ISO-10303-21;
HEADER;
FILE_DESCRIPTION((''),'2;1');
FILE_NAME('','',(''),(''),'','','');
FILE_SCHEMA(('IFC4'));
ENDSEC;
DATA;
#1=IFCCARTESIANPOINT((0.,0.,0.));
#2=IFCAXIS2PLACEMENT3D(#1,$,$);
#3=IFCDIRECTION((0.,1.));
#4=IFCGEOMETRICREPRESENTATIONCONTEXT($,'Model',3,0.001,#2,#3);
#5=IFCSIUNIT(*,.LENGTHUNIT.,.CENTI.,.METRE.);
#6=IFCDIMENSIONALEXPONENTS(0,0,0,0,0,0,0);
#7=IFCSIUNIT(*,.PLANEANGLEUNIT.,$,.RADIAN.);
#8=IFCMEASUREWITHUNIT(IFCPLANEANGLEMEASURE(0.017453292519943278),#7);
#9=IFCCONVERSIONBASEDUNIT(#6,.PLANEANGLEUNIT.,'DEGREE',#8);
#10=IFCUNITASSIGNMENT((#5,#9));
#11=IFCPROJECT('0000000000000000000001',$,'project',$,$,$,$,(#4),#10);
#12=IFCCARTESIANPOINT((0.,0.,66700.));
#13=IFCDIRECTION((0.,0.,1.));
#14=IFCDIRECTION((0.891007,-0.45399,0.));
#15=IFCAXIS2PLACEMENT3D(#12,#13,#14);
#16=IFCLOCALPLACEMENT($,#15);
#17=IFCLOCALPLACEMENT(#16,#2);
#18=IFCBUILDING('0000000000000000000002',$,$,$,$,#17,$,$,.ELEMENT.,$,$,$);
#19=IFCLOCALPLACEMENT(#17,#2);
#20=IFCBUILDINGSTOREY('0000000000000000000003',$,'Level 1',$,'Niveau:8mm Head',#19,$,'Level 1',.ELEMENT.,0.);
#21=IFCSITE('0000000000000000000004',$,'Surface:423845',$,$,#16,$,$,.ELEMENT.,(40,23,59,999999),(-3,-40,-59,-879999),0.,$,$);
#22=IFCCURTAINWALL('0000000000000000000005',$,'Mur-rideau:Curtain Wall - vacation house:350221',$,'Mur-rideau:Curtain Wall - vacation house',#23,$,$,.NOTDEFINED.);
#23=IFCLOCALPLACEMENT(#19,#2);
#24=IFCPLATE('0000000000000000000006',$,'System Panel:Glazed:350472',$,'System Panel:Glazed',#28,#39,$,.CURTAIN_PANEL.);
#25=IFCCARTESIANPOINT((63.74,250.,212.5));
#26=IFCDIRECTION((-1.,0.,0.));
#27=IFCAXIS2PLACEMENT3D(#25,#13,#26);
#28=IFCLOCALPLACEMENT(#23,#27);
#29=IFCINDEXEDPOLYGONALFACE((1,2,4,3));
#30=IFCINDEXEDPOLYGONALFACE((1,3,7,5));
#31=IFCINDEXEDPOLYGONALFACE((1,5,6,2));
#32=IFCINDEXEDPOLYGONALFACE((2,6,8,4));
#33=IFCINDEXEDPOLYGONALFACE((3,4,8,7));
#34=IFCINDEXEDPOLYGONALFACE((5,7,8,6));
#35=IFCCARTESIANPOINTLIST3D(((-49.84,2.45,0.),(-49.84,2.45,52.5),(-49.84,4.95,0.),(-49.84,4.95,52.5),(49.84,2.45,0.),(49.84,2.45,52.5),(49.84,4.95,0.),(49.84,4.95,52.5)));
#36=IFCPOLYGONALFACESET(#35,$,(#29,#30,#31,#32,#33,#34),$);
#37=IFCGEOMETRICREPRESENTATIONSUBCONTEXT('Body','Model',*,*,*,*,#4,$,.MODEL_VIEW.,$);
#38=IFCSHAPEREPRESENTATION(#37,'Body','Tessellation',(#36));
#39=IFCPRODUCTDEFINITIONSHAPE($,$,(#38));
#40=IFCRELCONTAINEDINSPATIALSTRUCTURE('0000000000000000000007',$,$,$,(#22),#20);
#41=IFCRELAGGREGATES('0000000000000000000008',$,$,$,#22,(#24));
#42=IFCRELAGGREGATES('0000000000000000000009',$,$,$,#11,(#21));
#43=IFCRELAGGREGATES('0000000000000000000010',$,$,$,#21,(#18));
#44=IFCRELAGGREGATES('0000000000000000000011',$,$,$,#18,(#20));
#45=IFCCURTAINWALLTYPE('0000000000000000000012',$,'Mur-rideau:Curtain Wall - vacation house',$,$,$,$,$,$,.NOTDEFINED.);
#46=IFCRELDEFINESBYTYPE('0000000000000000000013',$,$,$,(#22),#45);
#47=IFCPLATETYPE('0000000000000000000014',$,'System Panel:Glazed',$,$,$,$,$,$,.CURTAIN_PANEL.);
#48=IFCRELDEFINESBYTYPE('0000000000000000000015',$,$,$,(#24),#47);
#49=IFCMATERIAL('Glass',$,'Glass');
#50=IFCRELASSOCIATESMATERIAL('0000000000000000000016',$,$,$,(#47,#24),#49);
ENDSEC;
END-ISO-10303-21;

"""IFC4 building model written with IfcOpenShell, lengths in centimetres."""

from ifc_helpers import new_model, entity, si_unit, converted_unit, direction, frame, origin, origin_2d_with_axis, place, context, subcontext, project, spatial, rectangle, extrude, source, transform, mapped, material, type_object, type_shapes, element, aggregate, save


model = new_model("IFC4")

# Units and contexts
model_context = context("Model", 3, precision=0.001, world=origin(), true_north=direction((0.0, 1.0)))
body_context = subcontext(model_context, "Body", "Model", "MODEL_VIEW")
ifc_project = project(units=[si_unit("LENGTHUNIT", "METRE", prefix="CENTI"), converted_unit("PLANEANGLEUNIT", "DEGREE", entity("IfcPlaneAngleMeasure", 0.017453292519943278), si_unit("PLANEANGLEUNIT", "RADIAN"), dimensions=[0, 0, 0, 0, 0, 0, 0])], contexts=[model_context])

# Site, building, storey
site_placement = place(None, frame((0.0, 0.0, 66700.0), z_axis=(0.0, 0.0, 1.0), x_axis=(0.891007, -0.45399, 0.0)))
site = spatial("IfcSite", under=ifc_project, at=site_placement, Name="Surface:423845", CompositionType="ELEMENT", RefLatitude=(40, 23, 59, 999999), RefLongitude=(-3, -40, -59, -879999), RefElevation=0.0)
building_placement = place(site_placement, origin())
building = spatial("IfcBuilding", under=site, at=building_placement, CompositionType="ELEMENT")
storey_placement = place(building_placement, origin())
storey = spatial("IfcBuildingStorey", under=building, at=storey_placement, Name="Level 1", ObjectType="Niveau:8mm Head", LongName="Level 1", CompositionType="ELEMENT", Elevation=0.0)

# Curtain wall, plate
curtain_wall_type = type_object("IfcCurtainWallType", Name="Mur-rideau:Curtain Wall - vacation house", PredefinedType="NOTDEFINED")
curtain_wall_placement = place(storey_placement, origin())
curtain_wall = element("IfcCurtainWall", 1, at=curtain_wall_placement, inside=storey, type_object=curtain_wall_type, Name="Mur-rideau:Curtain Wall - vacation house:350221", ObjectType="Mur-rideau:Curtain Wall - vacation house", PredefinedType="NOTDEFINED")
ifc_material_1 = material(Name="Glass", Category="Glass")
plate_type = type_object("IfcPlateType", Name="System Panel:Glazed", PredefinedType="CURTAIN_PANEL", material=ifc_material_1)
shared_shape_1 = source(origin(), body_context, "Body", "SweptSolid", [
    extrude(rectangle(XDim=2.5, YDim=99.69, at=origin_2d_with_axis()), frame((0.0, 3.7, 0.0), z_axis=(0.0, 0.0, 1.0), x_axis=(0.0, 1.0, 0.0)), (0.0, 0.0, 1.0), 52.5),
])
type_shapes(plate_type, [shared_shape_1])
plate_placement = place(curtain_wall_placement, frame((63.74, 250.0, 212.5), z_axis=(0.0, 0.0, 1.0), x_axis=(-1.0, 0.0, 0.0)))
plate = element("IfcPlate", 2, at=plate_placement, type_object=plate_type, material=ifc_material_1, Name="System Panel:Glazed:350472", ObjectType="System Panel:Glazed", PredefinedType="CURTAIN_PANEL", context=body_context, shape_type="MappedRepresentation", body=[
    mapped(shared_shape_1, transform((0.0, 0.0, 0.0), scale=1.0)),
])
aggregate(curtain_wall, [plate])

save(model, "model.ifc")
